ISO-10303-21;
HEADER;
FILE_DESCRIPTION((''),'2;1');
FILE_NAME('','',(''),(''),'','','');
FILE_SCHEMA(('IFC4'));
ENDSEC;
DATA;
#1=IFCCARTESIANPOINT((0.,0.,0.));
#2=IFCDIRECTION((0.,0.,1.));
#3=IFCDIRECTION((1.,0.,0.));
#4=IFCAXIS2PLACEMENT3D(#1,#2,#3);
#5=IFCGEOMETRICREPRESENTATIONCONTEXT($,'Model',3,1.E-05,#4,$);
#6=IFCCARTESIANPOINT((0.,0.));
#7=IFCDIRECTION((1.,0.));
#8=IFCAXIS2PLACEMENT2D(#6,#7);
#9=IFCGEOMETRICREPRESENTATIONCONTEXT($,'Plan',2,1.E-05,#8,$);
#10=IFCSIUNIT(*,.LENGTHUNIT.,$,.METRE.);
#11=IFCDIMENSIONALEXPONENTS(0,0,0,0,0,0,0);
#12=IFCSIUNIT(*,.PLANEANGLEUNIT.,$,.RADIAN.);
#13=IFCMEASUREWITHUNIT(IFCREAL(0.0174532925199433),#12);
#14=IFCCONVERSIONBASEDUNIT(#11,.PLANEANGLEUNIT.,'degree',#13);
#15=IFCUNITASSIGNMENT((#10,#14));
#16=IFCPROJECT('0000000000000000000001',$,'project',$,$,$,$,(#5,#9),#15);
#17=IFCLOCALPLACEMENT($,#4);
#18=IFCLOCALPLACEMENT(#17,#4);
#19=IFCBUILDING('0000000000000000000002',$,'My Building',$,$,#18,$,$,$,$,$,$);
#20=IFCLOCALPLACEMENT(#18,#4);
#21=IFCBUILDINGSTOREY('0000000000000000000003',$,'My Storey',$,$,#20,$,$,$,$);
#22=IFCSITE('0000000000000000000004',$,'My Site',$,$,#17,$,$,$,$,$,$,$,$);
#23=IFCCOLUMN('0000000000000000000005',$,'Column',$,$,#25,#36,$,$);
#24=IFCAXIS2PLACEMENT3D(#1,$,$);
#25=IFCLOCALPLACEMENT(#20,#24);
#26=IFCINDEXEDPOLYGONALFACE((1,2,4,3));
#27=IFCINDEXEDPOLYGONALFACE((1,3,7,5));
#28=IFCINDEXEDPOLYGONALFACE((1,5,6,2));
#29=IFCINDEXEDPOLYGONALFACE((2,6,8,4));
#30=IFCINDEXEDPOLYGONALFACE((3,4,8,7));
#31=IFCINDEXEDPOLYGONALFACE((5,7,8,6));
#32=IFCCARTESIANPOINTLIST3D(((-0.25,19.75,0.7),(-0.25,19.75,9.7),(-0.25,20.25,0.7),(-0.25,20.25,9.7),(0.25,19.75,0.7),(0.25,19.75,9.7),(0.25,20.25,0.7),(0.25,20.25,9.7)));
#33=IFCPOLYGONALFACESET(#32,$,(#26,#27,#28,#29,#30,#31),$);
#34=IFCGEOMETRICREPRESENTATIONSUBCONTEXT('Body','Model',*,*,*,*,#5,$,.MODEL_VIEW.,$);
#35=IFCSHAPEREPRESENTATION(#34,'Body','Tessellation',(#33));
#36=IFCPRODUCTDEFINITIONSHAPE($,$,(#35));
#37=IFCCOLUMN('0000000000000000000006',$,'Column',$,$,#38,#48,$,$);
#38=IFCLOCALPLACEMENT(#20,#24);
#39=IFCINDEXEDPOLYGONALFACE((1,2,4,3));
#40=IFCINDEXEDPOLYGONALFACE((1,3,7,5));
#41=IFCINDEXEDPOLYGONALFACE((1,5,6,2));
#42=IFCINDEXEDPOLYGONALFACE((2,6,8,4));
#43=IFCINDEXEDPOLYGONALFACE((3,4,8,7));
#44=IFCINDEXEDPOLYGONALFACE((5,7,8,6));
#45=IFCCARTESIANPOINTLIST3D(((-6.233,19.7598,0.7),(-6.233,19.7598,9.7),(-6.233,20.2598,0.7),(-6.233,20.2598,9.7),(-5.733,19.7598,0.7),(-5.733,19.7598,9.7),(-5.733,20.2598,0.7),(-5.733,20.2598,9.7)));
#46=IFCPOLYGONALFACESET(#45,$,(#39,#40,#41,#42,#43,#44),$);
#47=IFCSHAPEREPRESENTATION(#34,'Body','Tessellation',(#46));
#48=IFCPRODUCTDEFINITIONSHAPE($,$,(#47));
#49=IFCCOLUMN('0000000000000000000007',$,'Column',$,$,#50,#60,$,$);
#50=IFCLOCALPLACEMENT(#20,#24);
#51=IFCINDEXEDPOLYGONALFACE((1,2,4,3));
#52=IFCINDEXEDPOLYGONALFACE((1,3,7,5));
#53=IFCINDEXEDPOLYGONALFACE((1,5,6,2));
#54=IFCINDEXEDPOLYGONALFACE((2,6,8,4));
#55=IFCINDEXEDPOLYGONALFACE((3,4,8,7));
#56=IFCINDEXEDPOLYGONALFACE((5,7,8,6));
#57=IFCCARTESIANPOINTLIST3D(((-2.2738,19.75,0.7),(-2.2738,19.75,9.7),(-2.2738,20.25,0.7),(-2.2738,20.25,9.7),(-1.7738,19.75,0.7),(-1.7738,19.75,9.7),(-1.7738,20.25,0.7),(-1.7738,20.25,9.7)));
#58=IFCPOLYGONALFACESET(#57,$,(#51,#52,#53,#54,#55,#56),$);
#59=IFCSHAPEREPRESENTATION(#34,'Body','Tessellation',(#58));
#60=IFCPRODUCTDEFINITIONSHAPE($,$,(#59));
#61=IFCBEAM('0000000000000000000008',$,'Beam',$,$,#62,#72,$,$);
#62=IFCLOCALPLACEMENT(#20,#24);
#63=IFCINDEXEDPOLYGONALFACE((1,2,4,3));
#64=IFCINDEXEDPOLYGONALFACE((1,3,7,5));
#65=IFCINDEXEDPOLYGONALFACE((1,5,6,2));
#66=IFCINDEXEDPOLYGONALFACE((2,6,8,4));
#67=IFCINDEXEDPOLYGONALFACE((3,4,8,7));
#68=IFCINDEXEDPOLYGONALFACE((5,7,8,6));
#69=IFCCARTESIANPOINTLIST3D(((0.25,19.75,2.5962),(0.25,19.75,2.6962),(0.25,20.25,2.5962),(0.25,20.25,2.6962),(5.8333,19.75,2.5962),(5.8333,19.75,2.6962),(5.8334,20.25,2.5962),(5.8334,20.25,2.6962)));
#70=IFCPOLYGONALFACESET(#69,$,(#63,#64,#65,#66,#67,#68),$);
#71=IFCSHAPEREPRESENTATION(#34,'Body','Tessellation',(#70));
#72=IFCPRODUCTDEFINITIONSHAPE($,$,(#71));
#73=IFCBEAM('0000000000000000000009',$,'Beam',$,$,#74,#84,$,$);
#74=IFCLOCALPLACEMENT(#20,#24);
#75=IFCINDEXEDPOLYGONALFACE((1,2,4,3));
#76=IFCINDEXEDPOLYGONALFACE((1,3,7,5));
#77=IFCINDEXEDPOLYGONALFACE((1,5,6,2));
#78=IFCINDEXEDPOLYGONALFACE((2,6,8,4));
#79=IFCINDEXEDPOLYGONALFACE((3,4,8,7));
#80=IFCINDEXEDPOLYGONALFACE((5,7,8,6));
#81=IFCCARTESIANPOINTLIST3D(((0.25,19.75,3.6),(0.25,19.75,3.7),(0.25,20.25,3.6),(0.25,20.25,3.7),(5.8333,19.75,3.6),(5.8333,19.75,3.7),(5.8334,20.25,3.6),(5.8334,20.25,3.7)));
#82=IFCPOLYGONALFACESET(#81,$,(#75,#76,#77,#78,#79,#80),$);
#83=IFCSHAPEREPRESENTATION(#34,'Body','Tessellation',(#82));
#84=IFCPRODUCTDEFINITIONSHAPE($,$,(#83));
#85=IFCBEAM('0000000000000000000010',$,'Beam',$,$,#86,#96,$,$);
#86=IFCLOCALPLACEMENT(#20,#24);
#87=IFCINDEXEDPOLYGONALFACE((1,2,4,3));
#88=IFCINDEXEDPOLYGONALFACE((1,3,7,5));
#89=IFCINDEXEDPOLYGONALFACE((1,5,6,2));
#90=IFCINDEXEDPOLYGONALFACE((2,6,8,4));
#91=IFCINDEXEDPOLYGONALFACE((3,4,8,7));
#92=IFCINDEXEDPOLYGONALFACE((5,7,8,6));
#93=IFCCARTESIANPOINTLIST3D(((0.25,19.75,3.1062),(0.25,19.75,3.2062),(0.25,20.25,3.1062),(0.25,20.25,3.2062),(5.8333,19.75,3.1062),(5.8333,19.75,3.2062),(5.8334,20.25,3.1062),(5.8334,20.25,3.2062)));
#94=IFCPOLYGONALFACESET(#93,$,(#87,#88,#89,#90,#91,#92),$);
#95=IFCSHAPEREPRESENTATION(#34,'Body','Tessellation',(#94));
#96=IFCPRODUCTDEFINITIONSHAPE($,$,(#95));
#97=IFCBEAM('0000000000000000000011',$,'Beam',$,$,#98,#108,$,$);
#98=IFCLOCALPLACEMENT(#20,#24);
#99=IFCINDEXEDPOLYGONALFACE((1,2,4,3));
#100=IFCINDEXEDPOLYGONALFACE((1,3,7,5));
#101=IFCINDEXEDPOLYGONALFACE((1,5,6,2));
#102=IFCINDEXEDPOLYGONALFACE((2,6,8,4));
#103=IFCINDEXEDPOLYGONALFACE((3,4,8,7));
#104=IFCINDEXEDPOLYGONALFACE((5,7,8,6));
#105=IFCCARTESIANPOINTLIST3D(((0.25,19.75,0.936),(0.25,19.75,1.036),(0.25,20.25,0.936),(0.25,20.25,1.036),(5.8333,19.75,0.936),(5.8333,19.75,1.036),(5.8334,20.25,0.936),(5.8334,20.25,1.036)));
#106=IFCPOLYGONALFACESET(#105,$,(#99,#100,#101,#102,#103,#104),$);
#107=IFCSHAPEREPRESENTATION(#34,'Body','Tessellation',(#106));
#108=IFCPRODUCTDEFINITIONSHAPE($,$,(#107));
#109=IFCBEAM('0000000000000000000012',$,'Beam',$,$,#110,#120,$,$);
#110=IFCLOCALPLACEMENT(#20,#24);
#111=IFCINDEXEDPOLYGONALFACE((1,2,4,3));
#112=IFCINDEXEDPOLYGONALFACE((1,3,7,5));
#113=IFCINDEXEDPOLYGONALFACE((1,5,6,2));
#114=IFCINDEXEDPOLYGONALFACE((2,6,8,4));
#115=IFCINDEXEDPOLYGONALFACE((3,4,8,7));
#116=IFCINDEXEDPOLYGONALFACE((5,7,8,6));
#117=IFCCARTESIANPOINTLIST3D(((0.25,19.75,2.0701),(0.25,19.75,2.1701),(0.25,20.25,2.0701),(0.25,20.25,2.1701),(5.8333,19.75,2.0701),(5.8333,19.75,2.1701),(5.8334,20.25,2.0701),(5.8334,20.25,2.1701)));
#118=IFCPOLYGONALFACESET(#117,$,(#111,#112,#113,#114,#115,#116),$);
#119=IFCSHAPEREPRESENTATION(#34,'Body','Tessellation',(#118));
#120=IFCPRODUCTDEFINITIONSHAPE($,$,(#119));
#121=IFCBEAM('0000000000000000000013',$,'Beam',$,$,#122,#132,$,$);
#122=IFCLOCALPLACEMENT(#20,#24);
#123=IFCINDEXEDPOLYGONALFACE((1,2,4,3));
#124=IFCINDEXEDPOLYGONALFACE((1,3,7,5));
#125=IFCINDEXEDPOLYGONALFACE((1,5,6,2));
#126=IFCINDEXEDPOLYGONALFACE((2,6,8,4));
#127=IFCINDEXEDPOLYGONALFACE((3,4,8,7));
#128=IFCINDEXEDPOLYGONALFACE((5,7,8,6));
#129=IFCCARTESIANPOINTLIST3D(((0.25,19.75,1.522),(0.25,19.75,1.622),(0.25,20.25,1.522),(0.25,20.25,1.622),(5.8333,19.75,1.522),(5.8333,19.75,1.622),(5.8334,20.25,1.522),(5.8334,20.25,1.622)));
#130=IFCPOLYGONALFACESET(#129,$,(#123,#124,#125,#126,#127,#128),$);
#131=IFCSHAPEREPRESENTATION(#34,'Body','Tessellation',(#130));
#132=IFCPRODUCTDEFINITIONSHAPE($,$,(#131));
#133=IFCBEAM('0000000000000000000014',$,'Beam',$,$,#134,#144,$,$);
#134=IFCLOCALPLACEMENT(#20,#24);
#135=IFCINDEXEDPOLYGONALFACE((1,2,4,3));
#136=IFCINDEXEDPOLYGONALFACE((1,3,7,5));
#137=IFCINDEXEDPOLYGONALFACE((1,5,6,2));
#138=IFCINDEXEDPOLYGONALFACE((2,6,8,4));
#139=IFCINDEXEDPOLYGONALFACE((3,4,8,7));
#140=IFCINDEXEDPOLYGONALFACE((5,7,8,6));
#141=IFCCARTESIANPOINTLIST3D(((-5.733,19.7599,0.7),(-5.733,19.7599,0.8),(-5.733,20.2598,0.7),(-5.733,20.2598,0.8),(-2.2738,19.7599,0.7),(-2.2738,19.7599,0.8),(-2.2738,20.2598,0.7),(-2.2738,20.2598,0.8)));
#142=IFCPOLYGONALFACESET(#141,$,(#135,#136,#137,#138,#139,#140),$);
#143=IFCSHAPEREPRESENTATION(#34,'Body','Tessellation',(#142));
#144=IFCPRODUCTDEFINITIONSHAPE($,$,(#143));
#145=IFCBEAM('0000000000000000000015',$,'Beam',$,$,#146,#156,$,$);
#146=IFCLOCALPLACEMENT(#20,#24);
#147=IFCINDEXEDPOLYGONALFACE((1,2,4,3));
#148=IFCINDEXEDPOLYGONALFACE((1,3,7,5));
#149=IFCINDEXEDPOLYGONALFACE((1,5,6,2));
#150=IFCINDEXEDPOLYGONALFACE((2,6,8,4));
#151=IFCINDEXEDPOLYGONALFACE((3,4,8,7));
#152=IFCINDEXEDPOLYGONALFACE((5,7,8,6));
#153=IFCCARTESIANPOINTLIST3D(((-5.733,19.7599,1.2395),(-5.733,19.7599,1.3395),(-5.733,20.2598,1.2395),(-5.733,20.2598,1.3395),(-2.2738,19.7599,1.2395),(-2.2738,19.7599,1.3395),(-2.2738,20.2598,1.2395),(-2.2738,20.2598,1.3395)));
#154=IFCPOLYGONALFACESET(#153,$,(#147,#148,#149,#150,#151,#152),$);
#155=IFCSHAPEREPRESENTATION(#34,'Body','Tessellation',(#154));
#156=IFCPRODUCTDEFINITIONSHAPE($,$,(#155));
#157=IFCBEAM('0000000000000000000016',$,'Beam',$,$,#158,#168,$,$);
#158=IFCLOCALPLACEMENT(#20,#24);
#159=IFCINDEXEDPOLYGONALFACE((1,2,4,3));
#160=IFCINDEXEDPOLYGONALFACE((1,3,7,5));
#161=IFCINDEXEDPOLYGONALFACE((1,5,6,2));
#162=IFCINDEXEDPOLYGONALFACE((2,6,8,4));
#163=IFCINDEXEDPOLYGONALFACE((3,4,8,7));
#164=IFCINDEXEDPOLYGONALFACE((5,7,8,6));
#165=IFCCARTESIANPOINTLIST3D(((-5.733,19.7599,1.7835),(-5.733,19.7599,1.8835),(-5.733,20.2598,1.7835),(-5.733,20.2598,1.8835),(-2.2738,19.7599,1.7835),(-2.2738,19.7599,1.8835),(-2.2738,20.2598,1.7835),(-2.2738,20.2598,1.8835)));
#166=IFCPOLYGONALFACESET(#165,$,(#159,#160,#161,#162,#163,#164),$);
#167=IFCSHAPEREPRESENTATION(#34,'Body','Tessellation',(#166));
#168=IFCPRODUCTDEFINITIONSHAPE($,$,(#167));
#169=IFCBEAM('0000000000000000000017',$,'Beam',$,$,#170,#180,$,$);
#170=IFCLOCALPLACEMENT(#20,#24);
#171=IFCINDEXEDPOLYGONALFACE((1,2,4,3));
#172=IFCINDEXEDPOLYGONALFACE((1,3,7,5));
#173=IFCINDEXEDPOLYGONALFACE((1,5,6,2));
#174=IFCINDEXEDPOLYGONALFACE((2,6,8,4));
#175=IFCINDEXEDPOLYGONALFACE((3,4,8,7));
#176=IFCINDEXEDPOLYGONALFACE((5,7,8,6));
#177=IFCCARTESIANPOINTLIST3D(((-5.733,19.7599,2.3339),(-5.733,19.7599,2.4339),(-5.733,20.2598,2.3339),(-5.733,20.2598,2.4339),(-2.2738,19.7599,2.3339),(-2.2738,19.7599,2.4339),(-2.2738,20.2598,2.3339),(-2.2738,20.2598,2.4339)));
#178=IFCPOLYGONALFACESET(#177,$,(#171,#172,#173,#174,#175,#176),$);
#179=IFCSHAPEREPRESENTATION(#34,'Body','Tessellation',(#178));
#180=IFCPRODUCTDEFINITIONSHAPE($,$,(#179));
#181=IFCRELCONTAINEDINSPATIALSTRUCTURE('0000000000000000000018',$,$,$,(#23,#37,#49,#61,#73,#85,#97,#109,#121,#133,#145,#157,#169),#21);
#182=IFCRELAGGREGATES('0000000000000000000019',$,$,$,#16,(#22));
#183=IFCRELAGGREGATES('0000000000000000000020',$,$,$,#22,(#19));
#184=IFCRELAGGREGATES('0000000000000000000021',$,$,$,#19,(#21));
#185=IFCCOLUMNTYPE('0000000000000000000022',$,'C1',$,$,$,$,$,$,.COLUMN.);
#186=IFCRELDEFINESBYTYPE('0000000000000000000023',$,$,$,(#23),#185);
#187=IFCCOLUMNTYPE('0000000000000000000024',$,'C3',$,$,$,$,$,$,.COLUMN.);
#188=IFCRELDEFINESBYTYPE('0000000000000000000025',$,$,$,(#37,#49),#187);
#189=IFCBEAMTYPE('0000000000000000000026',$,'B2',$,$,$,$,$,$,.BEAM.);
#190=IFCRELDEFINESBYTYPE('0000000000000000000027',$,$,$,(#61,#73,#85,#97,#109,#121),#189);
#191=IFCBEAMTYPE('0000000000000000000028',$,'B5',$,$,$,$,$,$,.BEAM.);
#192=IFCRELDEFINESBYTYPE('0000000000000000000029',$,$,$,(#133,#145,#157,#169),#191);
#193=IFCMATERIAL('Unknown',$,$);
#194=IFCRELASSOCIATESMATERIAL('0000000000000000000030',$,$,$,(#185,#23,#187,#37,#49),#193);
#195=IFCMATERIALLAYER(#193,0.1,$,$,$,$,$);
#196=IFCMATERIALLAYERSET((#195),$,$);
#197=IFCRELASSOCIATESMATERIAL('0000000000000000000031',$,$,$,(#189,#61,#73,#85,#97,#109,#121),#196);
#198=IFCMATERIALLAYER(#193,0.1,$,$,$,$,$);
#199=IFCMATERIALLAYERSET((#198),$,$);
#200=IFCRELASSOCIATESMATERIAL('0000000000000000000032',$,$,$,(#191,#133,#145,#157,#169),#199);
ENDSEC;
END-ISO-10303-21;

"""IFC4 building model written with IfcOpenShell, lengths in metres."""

from ifc_helpers import new_model, entity, si_unit, converted_unit, frame, origin_with_axes, origin_2d_with_axis, place, context, subcontext, project, spatial, indexed_curve, rectangle, outline, extrude, material, layer, layer_set, layer_usage, material_profile, profile_set, profile_usage, type_object, element, save


model = new_model("IFC4")

# Units and contexts
model_context = context("Model", 3, precision=1e-05, world=origin_with_axes())
plan_context = context("Plan", 2, precision=1e-05, world=origin_2d_with_axis())
body_context = subcontext(model_context, "Body", "Model", "MODEL_VIEW")
ifc_project = project(units=[si_unit("LENGTHUNIT", "METRE"), converted_unit("PLANEANGLEUNIT", "degree", entity("IfcReal", 0.0174532925199433), si_unit("PLANEANGLEUNIT", "RADIAN"), dimensions=[0, 0, 0, 0, 0, 0, 0])], contexts=[model_context, plan_context])

# Site, building, storey
site_placement = place(None, origin_with_axes())
site = spatial("IfcSite", under=ifc_project, at=site_placement, Name="My Site")
building_placement = place(site_placement, origin_with_axes())
building = spatial("IfcBuilding", under=site, at=building_placement, Name="My Building")
storey_placement = place(building_placement, origin_with_axes())
storey = spatial("IfcBuildingStorey", under=building, at=storey_placement, Name="My Storey")

# Columns
ifc_material = material(Name="Unknown")
ifc_material_profile_1 = material_profile(ifc_material, rectangle(XDim=0.5, YDim=0.5))
ifc_profile_set_1 = profile_set([ifc_material_profile_1])
ifc_profile_usage_1 = profile_usage(ifc_profile_set_1, cardinal=5)
column_type_1 = type_object("IfcColumnType", Name="C1", PredefinedType="COLUMN", material=ifc_profile_set_1)
column_1_placement = place(storey_placement, frame((0.0, 20.0, 0.7), z_axis=(0.0, 0.0, 1.0), x_axis=(1.0, 0.0, 0.0)))
element("IfcColumn", 1, at=column_1_placement, inside=storey, type_object=column_type_1, material=ifc_profile_usage_1, Name="Column", context=body_context, shape_type="SweptSolid", body=[
    extrude(rectangle(XDim=0.5, YDim=0.5), origin_with_axes(), (0.0, 0.0, 1.0), 9.0),
])
ifc_material_profile_2 = material_profile(ifc_material, rectangle(XDim=0.5, YDim=0.5))
ifc_profile_set_2 = profile_set([ifc_material_profile_2])
ifc_profile_usage_2 = profile_usage(ifc_profile_set_2, cardinal=8)
column_type_2 = type_object("IfcColumnType", Name="C3", PredefinedType="COLUMN", material=ifc_profile_set_2)
column_2_placement = place(storey_placement, frame((-5.983, 20.2598, 0.7), z_axis=(0.0, 0.0, 1.0), x_axis=(1.0, 0.0, 0.0)))
element("IfcColumn", 2, at=column_2_placement, inside=storey, type_object=column_type_2, material=ifc_profile_usage_2, Name="Column", context=body_context, shape_type="SweptSolid", body=[
    extrude(rectangle(XDim=0.5, YDim=0.5), frame((0.0, -0.25, 0.0), z_axis=(0.0, 0.0, 1.0), x_axis=(1.0, 0.0, 0.0)), (0.0, 0.0, 1.0), 9.0),
])
ifc_profile_usage_3 = profile_usage(ifc_profile_set_2, cardinal=8)
column_3_placement = place(storey_placement, frame((-2.0238, 20.25, 0.7), z_axis=(0.0, 0.0, 1.0), x_axis=(1.0, 0.0, 0.0)))
element("IfcColumn", 3, at=column_3_placement, inside=storey, type_object=column_type_2, material=ifc_profile_usage_3, Name="Column", context=body_context, shape_type="SweptSolid", body=[
    extrude(rectangle(XDim=0.5, YDim=0.5), frame((0.0, -0.25, 0.0), z_axis=(0.0, 0.0, 1.0), x_axis=(1.0, 0.0, 0.0)), (0.0, 0.0, 1.0), 9.0),
])

# Beams
ifc_layer_1 = layer(ifc_material, 0.1)
ifc_layer_set_1 = layer_set([ifc_layer_1])
ifc_layer_usage_1 = layer_usage(ifc_layer_set_1, "AXIS3", "POSITIVE", -0.1)
beam_type_1 = type_object("IfcBeamType", Name="B2", PredefinedType="BEAM", material=ifc_layer_set_1)
beam_1_placement = place(storey_placement, frame((0.25, 20.25, 2.6962), z_axis=(0.0, 0.0, 1.0), x_axis=(1.0, 0.0, 0.0)))
element("IfcBeam", 4, at=beam_1_placement, inside=storey, type_object=beam_type_1, material=ifc_layer_usage_1, Name="Beam", context=body_context, shape_type="SweptSolid", body=[
    extrude(outline(indexed_curve([(0.0, 0.0), (0.0, -0.5), (5.5833, -0.5), (5.5834, 0.0), (0.0, 0.0)])), frame((0.0, 0.0, -0.1), z_axis=(0.0, 0.0, 1.0), x_axis=(1.0, 0.0, 0.0)), (0.0, 0.0, 1.0), 0.1),
])
ifc_layer_usage_2 = layer_usage(ifc_layer_set_1, "AXIS3", "POSITIVE", -0.1)
beam_2_placement = place(storey_placement, frame((0.25, 20.25, 3.7), z_axis=(0.0, 0.0, 1.0), x_axis=(1.0, 0.0, 0.0)))
element("IfcBeam", 5, at=beam_2_placement, inside=storey, type_object=beam_type_1, material=ifc_layer_usage_2, Name="Beam", context=body_context, shape_type="SweptSolid", body=[
    extrude(outline(indexed_curve([(0.0, 0.0), (0.0, -0.5), (5.5833, -0.5), (5.5834, 0.0), (0.0, 0.0)])), frame((0.0, 0.0, -0.1), z_axis=(0.0, 0.0, 1.0), x_axis=(1.0, 0.0, 0.0)), (0.0, 0.0, 1.0), 0.1),
])
ifc_layer_usage_3 = layer_usage(ifc_layer_set_1, "AXIS3", "POSITIVE", -0.1)
beam_3_placement = place(storey_placement, frame((0.25, 20.25, 3.2062), z_axis=(0.0, 0.0, 1.0), x_axis=(1.0, 0.0, 0.0)))
element("IfcBeam", 6, at=beam_3_placement, inside=storey, type_object=beam_type_1, material=ifc_layer_usage_3, Name="Beam", context=body_context, shape_type="SweptSolid", body=[
    extrude(outline(indexed_curve([(0.0, 0.0), (0.0, -0.5), (5.5833, -0.5), (5.5834, 0.0), (0.0, 0.0)])), frame((0.0, 0.0, -0.1), z_axis=(0.0, 0.0, 1.0), x_axis=(1.0, 0.0, 0.0)), (0.0, 0.0, 1.0), 0.1),
])
ifc_layer_usage_4 = layer_usage(ifc_layer_set_1, "AXIS3", "POSITIVE", -0.1)
beam_4_placement = place(storey_placement, frame((0.25, 20.25, 1.036), z_axis=(0.0, 0.0, 1.0), x_axis=(1.0, 0.0, 0.0)))
element("IfcBeam", 7, at=beam_4_placement, inside=storey, type_object=beam_type_1, material=ifc_layer_usage_4, Name="Beam", context=body_context, shape_type="SweptSolid", body=[
    extrude(outline(indexed_curve([(0.0, 0.0), (0.0, -0.5), (5.5833, -0.5), (5.5834, 0.0), (0.0, 0.0)])), frame((0.0, 0.0, -0.1), z_axis=(0.0, 0.0, 1.0), x_axis=(1.0, 0.0, 0.0)), (0.0, 0.0, 1.0), 0.1),
])
ifc_layer_usage_5 = layer_usage(ifc_layer_set_1, "AXIS3", "POSITIVE", -0.1)
beam_5_placement = place(storey_placement, frame((0.25, 20.25, 2.1701), z_axis=(0.0, 0.0, 1.0), x_axis=(1.0, 0.0, 0.0)))
element("IfcBeam", 8, at=beam_5_placement, inside=storey, type_object=beam_type_1, material=ifc_layer_usage_5, Name="Beam", context=body_context, shape_type="SweptSolid", body=[
    extrude(outline(indexed_curve([(0.0, 0.0), (0.0, -0.5), (5.5833, -0.5), (5.5834, 0.0), (0.0, 0.0)])), frame((0.0, 0.0, -0.1), z_axis=(0.0, 0.0, 1.0), x_axis=(1.0, 0.0, 0.0)), (0.0, 0.0, 1.0), 0.1),
])
ifc_layer_usage_6 = layer_usage(ifc_layer_set_1, "AXIS3", "POSITIVE", -0.1)
beam_6_placement = place(storey_placement, frame((0.25, 20.25, 1.622), z_axis=(0.0, 0.0, 1.0), x_axis=(1.0, 0.0, 0.0)))
element("IfcBeam", 9, at=beam_6_placement, inside=storey, type_object=beam_type_1, material=ifc_layer_usage_6, Name="Beam", context=body_context, shape_type="SweptSolid", body=[
    extrude(outline(indexed_curve([(0.0, 0.0), (0.0, -0.5), (5.5833, -0.5), (5.5834, 0.0), (0.0, 0.0)])), frame((0.0, 0.0, -0.1), z_axis=(0.0, 0.0, 1.0), x_axis=(1.0, 0.0, 0.0)), (0.0, 0.0, 1.0), 0.1),
])
ifc_layer_2 = layer(ifc_material, 0.1)
ifc_layer_set_2 = layer_set([ifc_layer_2])
beam_type_2 = type_object("IfcBeamType", Name="B5", PredefinedType="BEAM", material=ifc_layer_set_2)
ifc_layer_usage_7 = layer_usage(ifc_layer_set_2, "AXIS3", "POSITIVE", -0.1)
beam_7_placement = place(storey_placement, frame((-2.2738, 20.2598, 0.8), z_axis=(0.0, 0.0, 1.0), x_axis=(1.0, 0.0, 0.0)))
element("IfcBeam", 10, at=beam_7_placement, inside=storey, type_object=beam_type_2, material=ifc_layer_usage_7, Name="Beam", context=body_context, shape_type="SweptSolid", body=[
    extrude(outline(indexed_curve([(0.0, 0.0), (0.0, -0.5), (-3.4592, -0.5), (-3.4592, 0.0), (0.0, 0.0), (0.0, 0.0)])), frame((0.0, 0.0, -0.1), z_axis=(0.0, 0.0, 1.0), x_axis=(1.0, 0.0, 0.0)), (0.0, 0.0, 1.0), 0.1),
])
ifc_layer_usage_8 = layer_usage(ifc_layer_set_2, "AXIS3", "POSITIVE", -0.1)
beam_8_placement = place(storey_placement, frame((-2.2738, 20.2598, 1.3395), z_axis=(0.0, 0.0, 1.0), x_axis=(1.0, 0.0, 0.0)))
element("IfcBeam", 11, at=beam_8_placement, inside=storey, type_object=beam_type_2, material=ifc_layer_usage_8, Name="Beam", context=body_context, shape_type="SweptSolid", body=[
    extrude(outline(indexed_curve([(0.0, 0.0), (0.0, -0.5), (-3.4592, -0.5), (-3.4592, 0.0), (0.0, 0.0), (0.0, 0.0)])), frame((0.0, 0.0, -0.1), z_axis=(0.0, 0.0, 1.0), x_axis=(1.0, 0.0, 0.0)), (0.0, 0.0, 1.0), 0.1),
])
ifc_layer_usage_9 = layer_usage(ifc_layer_set_2, "AXIS3", "POSITIVE", -0.1)
beam_9_placement = place(storey_placement, frame((-2.2738, 20.2598, 1.8835), z_axis=(0.0, 0.0, 1.0), x_axis=(1.0, 0.0, 0.0)))
element("IfcBeam", 12, at=beam_9_placement, inside=storey, type_object=beam_type_2, material=ifc_layer_usage_9, Name="Beam", context=body_context, shape_type="SweptSolid", body=[
    extrude(outline(indexed_curve([(0.0, 0.0), (0.0, -0.5), (-3.4592, -0.5), (-3.4592, 0.0), (0.0, 0.0), (0.0, 0.0)])), frame((0.0, 0.0, -0.1), z_axis=(0.0, 0.0, 1.0), x_axis=(1.0, 0.0, 0.0)), (0.0, 0.0, 1.0), 0.1),
])
ifc_layer_usage_10 = layer_usage(ifc_layer_set_2, "AXIS3", "POSITIVE", -0.1)
beam_10_placement = place(storey_placement, frame((-2.2738, 20.2598, 2.4339), z_axis=(0.0, 0.0, 1.0), x_axis=(1.0, 0.0, 0.0)))
element("IfcBeam", 13, at=beam_10_placement, inside=storey, type_object=beam_type_2, material=ifc_layer_usage_10, Name="Beam", context=body_context, shape_type="SweptSolid", body=[
    extrude(outline(indexed_curve([(0.0, 0.0), (0.0, -0.5), (-3.4592, -0.5), (-3.4592, 0.0), (0.0, 0.0), (0.0, 0.0)])), frame((0.0, 0.0, -0.1), z_axis=(0.0, 0.0, 1.0), x_axis=(1.0, 0.0, 0.0)), (0.0, 0.0, 1.0), 0.1),
])

save(model, "model.ifc")
